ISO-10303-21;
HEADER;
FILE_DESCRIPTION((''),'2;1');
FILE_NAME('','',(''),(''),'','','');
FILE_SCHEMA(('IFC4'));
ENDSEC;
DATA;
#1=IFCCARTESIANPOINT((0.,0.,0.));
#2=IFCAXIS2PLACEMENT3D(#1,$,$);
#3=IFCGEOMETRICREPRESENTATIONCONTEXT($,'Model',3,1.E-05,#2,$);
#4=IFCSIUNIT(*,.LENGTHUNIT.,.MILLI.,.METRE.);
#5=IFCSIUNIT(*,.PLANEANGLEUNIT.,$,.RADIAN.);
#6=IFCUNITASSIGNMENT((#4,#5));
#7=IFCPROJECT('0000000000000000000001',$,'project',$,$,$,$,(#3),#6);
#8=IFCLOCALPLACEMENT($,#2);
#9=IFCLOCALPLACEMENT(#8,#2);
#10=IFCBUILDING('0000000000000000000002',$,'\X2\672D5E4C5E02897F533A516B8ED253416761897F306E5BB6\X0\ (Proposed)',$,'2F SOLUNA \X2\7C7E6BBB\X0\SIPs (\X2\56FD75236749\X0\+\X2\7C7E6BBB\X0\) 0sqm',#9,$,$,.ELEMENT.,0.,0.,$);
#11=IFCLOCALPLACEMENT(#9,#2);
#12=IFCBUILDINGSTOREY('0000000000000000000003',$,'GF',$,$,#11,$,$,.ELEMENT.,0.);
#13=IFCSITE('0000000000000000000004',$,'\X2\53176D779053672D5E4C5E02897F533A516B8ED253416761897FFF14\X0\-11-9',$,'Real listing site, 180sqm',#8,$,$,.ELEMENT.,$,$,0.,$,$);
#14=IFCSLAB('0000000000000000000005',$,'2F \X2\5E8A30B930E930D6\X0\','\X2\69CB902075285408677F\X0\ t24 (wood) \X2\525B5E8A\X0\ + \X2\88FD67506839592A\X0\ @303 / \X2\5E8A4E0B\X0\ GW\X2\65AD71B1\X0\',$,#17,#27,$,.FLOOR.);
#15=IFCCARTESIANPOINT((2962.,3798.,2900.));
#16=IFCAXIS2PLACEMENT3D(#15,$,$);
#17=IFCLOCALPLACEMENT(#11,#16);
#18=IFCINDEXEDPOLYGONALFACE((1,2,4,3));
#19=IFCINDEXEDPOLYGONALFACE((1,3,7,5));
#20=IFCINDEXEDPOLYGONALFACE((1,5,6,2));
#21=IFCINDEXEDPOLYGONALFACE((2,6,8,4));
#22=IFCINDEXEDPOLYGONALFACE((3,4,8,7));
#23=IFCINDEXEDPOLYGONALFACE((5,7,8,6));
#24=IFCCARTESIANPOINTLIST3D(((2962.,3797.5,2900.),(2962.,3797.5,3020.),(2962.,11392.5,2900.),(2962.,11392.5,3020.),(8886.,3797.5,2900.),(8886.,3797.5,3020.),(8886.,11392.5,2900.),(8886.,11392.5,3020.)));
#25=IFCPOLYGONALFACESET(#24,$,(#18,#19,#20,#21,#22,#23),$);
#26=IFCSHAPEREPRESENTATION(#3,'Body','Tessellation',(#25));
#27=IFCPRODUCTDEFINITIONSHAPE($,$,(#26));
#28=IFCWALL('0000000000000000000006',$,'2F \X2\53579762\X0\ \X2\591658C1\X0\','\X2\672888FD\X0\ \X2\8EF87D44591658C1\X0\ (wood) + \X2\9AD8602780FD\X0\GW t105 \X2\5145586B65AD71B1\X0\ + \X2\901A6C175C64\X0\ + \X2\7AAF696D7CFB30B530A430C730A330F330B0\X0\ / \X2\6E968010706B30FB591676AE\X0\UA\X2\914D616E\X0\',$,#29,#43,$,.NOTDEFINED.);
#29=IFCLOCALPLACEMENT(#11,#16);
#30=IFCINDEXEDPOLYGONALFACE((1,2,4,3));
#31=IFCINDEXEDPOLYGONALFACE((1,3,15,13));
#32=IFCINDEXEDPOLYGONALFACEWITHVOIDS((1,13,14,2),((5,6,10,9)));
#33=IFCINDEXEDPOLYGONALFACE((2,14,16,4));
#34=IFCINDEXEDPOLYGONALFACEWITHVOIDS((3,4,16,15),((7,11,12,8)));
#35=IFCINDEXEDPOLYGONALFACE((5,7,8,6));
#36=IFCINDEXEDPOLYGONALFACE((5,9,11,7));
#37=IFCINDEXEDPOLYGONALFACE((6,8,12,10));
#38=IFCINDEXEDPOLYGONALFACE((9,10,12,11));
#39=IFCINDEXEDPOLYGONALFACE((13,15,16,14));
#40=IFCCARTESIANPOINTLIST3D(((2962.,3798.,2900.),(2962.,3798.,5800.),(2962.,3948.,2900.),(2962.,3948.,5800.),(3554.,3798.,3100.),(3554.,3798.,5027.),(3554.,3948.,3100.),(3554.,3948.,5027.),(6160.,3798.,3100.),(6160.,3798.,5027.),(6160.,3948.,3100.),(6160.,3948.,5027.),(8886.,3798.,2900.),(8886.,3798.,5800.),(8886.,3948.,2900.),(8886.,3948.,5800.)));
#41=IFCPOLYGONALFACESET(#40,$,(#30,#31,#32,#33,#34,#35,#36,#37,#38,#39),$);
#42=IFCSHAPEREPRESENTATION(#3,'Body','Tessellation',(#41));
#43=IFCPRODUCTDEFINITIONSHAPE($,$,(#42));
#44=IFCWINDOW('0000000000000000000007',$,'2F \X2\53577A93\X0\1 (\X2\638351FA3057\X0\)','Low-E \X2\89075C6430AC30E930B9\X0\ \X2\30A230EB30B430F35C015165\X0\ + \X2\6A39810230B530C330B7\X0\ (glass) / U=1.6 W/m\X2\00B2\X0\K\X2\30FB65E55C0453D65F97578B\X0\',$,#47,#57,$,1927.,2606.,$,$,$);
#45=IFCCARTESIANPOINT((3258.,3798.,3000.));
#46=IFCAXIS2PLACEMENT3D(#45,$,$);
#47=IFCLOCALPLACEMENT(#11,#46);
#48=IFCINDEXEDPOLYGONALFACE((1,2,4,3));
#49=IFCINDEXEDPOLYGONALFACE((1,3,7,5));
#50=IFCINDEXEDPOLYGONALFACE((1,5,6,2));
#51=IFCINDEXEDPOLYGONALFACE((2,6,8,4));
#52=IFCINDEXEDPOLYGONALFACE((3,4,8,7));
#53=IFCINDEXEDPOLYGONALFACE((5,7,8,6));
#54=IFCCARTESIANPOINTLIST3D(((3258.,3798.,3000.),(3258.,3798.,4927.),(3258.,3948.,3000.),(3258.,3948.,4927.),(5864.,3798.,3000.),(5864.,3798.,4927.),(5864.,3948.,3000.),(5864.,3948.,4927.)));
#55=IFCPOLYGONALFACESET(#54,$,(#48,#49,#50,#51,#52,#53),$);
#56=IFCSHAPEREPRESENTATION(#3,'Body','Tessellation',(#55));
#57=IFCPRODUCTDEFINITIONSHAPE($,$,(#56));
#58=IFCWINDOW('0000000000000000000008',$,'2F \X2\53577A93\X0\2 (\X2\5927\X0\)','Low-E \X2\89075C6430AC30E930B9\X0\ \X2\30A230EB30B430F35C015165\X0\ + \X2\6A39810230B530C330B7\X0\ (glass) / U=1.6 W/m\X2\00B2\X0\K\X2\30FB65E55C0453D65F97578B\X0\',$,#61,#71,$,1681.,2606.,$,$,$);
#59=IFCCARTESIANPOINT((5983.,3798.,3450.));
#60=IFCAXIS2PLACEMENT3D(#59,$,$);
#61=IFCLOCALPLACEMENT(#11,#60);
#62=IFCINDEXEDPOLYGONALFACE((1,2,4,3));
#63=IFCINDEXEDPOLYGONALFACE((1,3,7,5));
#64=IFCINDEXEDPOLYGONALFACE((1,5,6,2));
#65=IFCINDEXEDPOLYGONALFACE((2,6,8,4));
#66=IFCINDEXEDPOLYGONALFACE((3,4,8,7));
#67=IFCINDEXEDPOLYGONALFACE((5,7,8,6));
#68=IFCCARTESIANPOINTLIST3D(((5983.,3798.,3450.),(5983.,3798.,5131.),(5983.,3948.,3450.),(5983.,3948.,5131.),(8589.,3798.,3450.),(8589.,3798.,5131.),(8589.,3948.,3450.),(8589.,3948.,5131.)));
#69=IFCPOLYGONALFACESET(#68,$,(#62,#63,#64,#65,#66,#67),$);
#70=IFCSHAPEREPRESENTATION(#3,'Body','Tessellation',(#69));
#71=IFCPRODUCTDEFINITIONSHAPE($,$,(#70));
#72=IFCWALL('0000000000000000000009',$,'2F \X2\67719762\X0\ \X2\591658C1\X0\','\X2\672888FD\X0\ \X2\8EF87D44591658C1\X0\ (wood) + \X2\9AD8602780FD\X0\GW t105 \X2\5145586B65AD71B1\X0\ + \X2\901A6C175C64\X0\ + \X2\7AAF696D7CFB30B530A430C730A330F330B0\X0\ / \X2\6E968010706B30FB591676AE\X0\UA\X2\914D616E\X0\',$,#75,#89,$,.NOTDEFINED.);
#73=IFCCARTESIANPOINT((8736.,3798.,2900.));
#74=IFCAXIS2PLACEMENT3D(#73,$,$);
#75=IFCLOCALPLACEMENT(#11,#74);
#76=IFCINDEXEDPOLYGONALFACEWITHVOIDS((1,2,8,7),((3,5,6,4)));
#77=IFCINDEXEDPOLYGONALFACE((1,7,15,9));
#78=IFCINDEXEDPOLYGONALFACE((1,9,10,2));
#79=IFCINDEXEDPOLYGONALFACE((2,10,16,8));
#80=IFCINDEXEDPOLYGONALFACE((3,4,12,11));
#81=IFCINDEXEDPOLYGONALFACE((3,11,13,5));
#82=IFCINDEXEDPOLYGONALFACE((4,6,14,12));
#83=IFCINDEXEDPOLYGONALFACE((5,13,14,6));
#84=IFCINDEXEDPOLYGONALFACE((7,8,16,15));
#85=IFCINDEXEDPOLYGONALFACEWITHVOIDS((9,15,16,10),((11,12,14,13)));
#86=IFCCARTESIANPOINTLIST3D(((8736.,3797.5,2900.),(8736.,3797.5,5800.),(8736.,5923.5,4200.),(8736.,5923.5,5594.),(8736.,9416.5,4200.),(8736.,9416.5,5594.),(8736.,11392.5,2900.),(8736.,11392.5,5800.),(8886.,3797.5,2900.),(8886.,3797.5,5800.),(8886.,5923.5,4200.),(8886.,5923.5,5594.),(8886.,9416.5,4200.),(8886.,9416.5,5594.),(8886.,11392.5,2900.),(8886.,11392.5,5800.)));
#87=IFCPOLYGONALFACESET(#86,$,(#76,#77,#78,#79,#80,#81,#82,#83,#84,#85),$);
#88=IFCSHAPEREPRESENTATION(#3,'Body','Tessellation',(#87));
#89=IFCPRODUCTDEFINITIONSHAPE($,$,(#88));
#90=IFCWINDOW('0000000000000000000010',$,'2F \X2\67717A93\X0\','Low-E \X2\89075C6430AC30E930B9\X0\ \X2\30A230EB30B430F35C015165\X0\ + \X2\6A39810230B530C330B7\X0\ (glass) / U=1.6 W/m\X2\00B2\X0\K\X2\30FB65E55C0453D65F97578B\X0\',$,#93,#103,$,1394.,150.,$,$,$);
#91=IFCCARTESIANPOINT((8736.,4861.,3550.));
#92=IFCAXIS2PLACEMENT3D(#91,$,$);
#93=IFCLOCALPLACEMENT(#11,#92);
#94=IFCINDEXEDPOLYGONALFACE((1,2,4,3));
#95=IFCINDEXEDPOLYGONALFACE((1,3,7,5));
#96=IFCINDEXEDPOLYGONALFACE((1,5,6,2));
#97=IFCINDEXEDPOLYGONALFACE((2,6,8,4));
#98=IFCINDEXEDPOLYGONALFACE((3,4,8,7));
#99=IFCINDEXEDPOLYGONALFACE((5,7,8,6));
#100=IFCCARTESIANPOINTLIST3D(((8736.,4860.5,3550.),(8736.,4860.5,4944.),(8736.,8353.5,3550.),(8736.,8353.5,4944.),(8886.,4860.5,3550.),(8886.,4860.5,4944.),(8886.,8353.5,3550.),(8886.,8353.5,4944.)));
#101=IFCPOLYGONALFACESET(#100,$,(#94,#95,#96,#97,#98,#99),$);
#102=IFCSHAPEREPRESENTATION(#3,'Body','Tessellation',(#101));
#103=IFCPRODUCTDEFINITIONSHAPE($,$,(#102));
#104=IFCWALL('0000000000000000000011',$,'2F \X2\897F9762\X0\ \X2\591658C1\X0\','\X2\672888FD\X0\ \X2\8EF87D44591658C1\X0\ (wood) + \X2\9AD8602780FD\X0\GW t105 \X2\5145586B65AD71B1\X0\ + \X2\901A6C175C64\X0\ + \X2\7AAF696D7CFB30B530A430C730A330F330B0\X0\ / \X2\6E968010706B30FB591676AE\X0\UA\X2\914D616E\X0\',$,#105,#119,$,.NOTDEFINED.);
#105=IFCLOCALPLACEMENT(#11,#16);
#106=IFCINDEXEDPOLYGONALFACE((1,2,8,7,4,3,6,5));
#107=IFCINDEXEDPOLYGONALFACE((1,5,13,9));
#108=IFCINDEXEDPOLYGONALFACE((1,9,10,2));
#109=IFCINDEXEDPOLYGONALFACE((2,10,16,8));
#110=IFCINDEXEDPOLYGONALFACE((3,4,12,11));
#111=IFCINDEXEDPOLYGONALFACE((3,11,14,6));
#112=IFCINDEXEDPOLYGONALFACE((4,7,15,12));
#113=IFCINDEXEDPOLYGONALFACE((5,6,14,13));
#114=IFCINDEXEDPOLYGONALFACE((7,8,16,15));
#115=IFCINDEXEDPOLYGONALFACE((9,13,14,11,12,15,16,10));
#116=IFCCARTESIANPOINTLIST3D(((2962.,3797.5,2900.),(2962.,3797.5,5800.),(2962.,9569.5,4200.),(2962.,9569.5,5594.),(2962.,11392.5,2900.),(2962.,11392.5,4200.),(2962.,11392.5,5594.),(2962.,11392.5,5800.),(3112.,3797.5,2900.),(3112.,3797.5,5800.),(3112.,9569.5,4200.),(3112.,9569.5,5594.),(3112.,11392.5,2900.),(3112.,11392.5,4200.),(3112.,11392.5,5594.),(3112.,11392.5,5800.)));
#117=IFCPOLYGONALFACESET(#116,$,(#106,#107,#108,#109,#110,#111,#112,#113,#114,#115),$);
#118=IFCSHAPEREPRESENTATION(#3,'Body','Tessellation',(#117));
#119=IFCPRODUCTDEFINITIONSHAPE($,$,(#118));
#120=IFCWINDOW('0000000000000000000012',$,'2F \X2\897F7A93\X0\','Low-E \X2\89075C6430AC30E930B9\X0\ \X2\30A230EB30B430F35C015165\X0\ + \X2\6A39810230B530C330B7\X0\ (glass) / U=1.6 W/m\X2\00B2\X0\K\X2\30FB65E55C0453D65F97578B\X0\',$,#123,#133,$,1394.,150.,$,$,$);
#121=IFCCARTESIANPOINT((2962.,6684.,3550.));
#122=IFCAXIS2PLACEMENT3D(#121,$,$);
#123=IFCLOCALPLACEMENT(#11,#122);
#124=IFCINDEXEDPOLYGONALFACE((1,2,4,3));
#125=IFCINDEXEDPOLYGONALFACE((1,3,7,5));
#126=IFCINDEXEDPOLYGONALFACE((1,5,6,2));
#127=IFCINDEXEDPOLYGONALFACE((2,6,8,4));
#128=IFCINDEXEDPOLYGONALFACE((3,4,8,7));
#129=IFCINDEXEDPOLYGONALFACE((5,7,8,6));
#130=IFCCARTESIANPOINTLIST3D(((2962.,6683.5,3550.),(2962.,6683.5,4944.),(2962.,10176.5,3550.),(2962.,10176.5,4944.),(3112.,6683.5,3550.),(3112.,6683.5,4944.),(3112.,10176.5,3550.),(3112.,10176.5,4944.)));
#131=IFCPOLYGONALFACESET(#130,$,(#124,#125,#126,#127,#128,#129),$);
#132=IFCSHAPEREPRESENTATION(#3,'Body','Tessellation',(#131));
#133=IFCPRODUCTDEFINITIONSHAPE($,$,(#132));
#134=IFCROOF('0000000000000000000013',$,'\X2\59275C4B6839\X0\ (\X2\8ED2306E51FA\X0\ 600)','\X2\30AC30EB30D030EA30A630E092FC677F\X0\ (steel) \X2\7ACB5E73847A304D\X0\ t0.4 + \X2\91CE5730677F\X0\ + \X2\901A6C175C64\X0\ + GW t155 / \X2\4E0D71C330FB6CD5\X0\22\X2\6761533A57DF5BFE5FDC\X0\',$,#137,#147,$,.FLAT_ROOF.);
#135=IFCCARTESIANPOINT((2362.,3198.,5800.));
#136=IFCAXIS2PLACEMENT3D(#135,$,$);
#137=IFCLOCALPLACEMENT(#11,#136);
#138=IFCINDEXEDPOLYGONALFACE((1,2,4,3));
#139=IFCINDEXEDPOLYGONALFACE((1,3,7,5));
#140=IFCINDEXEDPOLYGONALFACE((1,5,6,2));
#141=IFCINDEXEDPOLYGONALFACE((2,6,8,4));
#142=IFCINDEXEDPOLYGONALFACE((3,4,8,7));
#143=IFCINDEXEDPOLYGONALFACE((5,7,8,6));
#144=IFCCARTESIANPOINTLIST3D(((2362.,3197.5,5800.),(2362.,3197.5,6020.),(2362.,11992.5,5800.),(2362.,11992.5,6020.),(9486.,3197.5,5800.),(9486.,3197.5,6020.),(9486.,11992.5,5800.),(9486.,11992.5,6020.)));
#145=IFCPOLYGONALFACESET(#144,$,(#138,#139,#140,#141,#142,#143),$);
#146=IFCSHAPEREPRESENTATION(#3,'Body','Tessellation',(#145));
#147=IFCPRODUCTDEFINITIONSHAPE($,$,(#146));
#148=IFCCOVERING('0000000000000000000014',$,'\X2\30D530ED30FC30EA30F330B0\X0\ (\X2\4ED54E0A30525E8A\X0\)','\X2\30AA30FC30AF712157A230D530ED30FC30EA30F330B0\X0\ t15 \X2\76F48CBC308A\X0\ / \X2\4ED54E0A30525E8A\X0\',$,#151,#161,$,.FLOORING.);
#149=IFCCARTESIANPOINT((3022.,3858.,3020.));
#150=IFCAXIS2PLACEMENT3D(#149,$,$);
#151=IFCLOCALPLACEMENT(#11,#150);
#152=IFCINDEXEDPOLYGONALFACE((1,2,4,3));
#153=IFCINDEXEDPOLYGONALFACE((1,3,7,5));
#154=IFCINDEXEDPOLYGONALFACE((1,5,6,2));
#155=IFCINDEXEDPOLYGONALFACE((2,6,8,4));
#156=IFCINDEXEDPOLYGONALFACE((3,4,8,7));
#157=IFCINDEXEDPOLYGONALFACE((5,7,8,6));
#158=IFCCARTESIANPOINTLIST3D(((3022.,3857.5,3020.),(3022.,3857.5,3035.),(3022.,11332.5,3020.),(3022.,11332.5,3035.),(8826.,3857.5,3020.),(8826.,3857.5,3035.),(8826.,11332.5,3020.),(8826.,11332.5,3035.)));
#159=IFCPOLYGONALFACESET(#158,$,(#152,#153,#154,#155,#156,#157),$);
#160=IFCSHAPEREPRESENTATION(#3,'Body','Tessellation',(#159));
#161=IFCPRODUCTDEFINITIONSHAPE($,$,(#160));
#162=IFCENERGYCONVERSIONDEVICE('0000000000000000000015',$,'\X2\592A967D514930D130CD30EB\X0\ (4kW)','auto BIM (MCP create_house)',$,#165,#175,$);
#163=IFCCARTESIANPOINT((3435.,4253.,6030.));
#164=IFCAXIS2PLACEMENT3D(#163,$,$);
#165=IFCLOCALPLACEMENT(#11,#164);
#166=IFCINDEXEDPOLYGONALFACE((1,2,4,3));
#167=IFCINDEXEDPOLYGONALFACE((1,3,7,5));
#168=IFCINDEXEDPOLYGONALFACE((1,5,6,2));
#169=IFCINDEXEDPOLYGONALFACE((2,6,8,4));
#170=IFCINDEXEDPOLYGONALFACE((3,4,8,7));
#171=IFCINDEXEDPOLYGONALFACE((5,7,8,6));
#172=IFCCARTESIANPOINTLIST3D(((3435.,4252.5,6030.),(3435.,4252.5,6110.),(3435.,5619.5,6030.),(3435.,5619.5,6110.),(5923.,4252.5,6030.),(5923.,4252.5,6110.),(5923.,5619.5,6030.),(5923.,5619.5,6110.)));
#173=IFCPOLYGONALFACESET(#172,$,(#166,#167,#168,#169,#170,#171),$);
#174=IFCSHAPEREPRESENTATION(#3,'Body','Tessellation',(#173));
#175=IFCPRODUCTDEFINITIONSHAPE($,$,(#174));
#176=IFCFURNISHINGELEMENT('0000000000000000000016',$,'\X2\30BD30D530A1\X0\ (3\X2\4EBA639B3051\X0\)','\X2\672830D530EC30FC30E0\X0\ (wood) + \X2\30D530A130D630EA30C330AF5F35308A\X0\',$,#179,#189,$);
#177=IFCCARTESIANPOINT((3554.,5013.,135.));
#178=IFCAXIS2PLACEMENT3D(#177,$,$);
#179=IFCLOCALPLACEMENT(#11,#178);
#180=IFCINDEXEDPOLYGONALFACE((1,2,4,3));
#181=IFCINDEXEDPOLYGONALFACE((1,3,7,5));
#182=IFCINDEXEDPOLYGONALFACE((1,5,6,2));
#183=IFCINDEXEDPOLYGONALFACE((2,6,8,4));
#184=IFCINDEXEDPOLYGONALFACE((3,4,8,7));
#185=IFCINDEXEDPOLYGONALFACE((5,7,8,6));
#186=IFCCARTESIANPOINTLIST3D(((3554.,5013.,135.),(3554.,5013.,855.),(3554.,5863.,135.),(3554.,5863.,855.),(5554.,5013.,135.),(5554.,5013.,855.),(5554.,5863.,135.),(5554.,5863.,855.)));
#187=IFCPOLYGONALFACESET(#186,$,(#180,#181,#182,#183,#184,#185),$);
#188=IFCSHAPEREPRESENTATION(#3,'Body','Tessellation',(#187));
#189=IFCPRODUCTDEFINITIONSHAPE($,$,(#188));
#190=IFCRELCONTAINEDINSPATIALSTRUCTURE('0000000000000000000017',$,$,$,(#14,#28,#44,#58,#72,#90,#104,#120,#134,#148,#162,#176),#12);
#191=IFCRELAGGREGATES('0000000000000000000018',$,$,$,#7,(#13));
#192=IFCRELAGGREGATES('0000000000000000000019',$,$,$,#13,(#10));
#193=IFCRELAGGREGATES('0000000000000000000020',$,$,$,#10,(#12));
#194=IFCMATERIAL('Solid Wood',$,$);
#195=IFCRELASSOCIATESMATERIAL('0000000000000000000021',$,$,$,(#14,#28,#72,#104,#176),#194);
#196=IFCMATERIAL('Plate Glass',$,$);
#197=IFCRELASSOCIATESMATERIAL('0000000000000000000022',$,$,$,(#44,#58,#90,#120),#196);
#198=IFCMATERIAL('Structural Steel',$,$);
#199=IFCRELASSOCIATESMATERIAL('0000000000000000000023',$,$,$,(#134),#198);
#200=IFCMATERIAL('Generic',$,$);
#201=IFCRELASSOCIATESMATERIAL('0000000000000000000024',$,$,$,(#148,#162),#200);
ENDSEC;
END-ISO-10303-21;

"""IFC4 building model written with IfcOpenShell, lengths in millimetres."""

from ifc_helpers import new_model, si_unit, frame, frame_2d, origin, place, context, project, spatial, rectangle, extrude, material, element, fill, save


model = new_model("IFC4")

# Units and contexts
model_context = context("Model", 3, precision=1e-05, world=origin())
ifc_project = project(units=[si_unit("LENGTHUNIT", "METRE", prefix="MILLI"), si_unit("PLANEANGLEUNIT", "RADIAN")], contexts=[model_context])

# Site, building, storey
site_placement = place(None, origin())
site = spatial("IfcSite", under=ifc_project, at=site_placement, Name="北海道札幌市西区八軒十条西４-11-9", ObjectType="Real listing site, 180sqm", CompositionType="ELEMENT", RefElevation=0.0)
building_placement = place(site_placement, origin())
building = spatial("IfcBuilding", under=site, at=building_placement, Name="札幌市西区八軒十条西の家 (Proposed)", ObjectType="2F SOLUNA 籾殻SIPs (国産杉+籾殻) 0sqm", CompositionType="ELEMENT", ElevationOfRefHeight=0.0, ElevationOfTerrain=0.0)
storey_placement = place(building_placement, origin())
storey = spatial("IfcBuildingStorey", under=building, at=storey_placement, Name="GF", CompositionType="ELEMENT", Elevation=0.0)

# Slab
ifc_material_1 = material(Name="Solid Wood")
slab_placement = place(storey_placement, frame((2962.0, 3798.0, 2900.0)))
element("IfcSlab", 1, at=slab_placement, inside=storey, material=ifc_material_1, Name="2F 床スラブ", Description="構造用合板 t24 (wood) 剛床 + 製材根太 @303 / 床下 GW断熱", PredefinedType="FLOOR", context=model_context, shape_type="SweptSolid", body=[
    extrude(rectangle(XDim=5924.0, YDim=7595.0, at=frame_2d((2962.0, 3797.0))), frame((2962.0, 3798.0, 2900.0)), (0.0, 0.0, 1.0), 120.0),
])

# Wall, openings, windows
wall_1_placement = place(storey_placement, frame((2962.0, 3798.0, 2900.0)))
wall_1 = element("IfcWall", 2, at=wall_1_placement, inside=storey, material=ifc_material_1, Name="2F 南面 外壁", Description="木製 軸組外壁 (wood) + 高性能GW t105 充填断熱 + 通気層 + 窯業系サイディング / 準耐火・外皮UA配慮", PredefinedType="NOTDEFINED", context=model_context, shape_type="SweptSolid", body=[
    extrude(rectangle(XDim=5924.0, YDim=150.0, at=frame_2d((2962.0, 75.0))), frame((2962.0, 3798.0, 2900.0)), (0.0, 0.0, 1.0), 2900.0),
])
opening_1_placement = place(storey_placement, frame((3258.0, 3798.0, 3000.0)))
opening_1 = element("IfcOpeningElement", 3, at=opening_1_placement, cuts=wall_1, PredefinedType="NOTDEFINED", context=model_context, shape_type="SweptSolid", body=[
    extrude(rectangle(XDim=2606.0, YDim=150.0, at=frame_2d((1303.0, 75.0))), frame((3258.0, 3798.0, 3000.0)), (0.0, 0.0, 1.0), 1927.0),
])
opening_2_placement = place(storey_placement, frame((5983.0, 3798.0, 3450.0)))
opening_2 = element("IfcOpeningElement", 4, at=opening_2_placement, cuts=wall_1, PredefinedType="NOTDEFINED", context=model_context, shape_type="SweptSolid", body=[
    extrude(rectangle(XDim=2606.0, YDim=150.0, at=frame_2d((1303.0, 75.0))), frame((5983.0, 3798.0, 3450.0)), (0.0, 0.0, 1.0), 1681.0),
])
ifc_material_2 = material(Name="Plate Glass")
window_1_placement = place(storey_placement, frame((3258.0, 3798.0, 3000.0)))
window_1 = element("IfcWindow", 5, at=window_1_placement, inside=storey, material=ifc_material_2, Name="2F 南窓1 (掃出し)", Description="Low-E 複層ガラス アルゴン封入 + 樹脂サッシ (glass) / U=1.6 W/m²K・日射取得型", OverallHeight=1927.0, OverallWidth=2606.0, context=model_context, shape_type="SweptSolid", body=[
    extrude(rectangle(XDim=2606.0, YDim=150.0, at=frame_2d((1303.0, 75.0))), frame((3258.0, 3798.0, 3000.0)), (0.0, 0.0, 1.0), 1927.0),
])
fill(opening_1, window_1)
window_2_placement = place(storey_placement, frame((5983.0, 3798.0, 3450.0)))
window_2 = element("IfcWindow", 6, at=window_2_placement, inside=storey, material=ifc_material_2, Name="2F 南窓2 (大)", Description="Low-E 複層ガラス アルゴン封入 + 樹脂サッシ (glass) / U=1.6 W/m²K・日射取得型", OverallHeight=1681.0, OverallWidth=2606.0, context=model_context, shape_type="SweptSolid", body=[
    extrude(rectangle(XDim=2606.0, YDim=150.0, at=frame_2d((1303.0, 75.0))), frame((5983.0, 3798.0, 3450.0)), (0.0, 0.0, 1.0), 1681.0),
])
fill(opening_2, window_2)

# Walls, openings, windows
wall_2_placement = place(storey_placement, frame((8736.0, 3798.0, 2900.0)))
wall_2 = element("IfcWall", 7, at=wall_2_placement, inside=storey, material=ifc_material_1, Name="2F 東面 外壁", Description="木製 軸組外壁 (wood) + 高性能GW t105 充填断熱 + 通気層 + 窯業系サイディング / 準耐火・外皮UA配慮", PredefinedType="NOTDEFINED", context=model_context, shape_type="SweptSolid", body=[
    extrude(rectangle(XDim=150.0, YDim=7595.0, at=frame_2d((75.0, 3797.0))), frame((8736.0, 3798.0, 2900.0)), (0.0, 0.0, 1.0), 2900.0),
])
opening_3_placement = place(storey_placement, frame((8736.0, 4861.0, 3550.0)))
opening_3 = element("IfcOpeningElement", 8, at=opening_3_placement, cuts=wall_2, PredefinedType="NOTDEFINED", context=model_context, shape_type="SweptSolid", body=[
    extrude(rectangle(XDim=150.0, YDim=3493.0, at=frame_2d((75.0, 1746.0))), frame((8736.0, 4861.0, 3550.0)), (0.0, 0.0, 1.0), 1394.0),
])
window_3_placement = place(storey_placement, frame((8736.0, 4861.0, 3550.0)))
window_3 = element("IfcWindow", 9, at=window_3_placement, inside=storey, material=ifc_material_2, Name="2F 東窓", Description="Low-E 複層ガラス アルゴン封入 + 樹脂サッシ (glass) / U=1.6 W/m²K・日射取得型", OverallHeight=1394.0, OverallWidth=150.0, context=model_context, shape_type="SweptSolid", body=[
    extrude(rectangle(XDim=150.0, YDim=3493.0, at=frame_2d((75.0, 1746.0))), frame((8736.0, 4861.0, 3550.0)), (0.0, 0.0, 1.0), 1394.0),
])
fill(opening_3, window_3)
wall_3_placement = place(storey_placement, frame((2962.0, 3798.0, 2900.0)))
wall_3 = element("IfcWall", 10, at=wall_3_placement, inside=storey, material=ifc_material_1, Name="2F 西面 外壁", Description="木製 軸組外壁 (wood) + 高性能GW t105 充填断熱 + 通気層 + 窯業系サイディング / 準耐火・外皮UA配慮", PredefinedType="NOTDEFINED", context=model_context, shape_type="SweptSolid", body=[
    extrude(rectangle(XDim=150.0, YDim=7595.0, at=frame_2d((75.0, 3797.0))), frame((2962.0, 3798.0, 2900.0)), (0.0, 0.0, 1.0), 2900.0),
])
opening_4_placement = place(storey_placement, frame((2962.0, 6684.0, 3550.0)))
opening_4 = element("IfcOpeningElement", 11, at=opening_4_placement, cuts=wall_3, PredefinedType="NOTDEFINED", context=model_context, shape_type="SweptSolid", body=[
    extrude(rectangle(XDim=150.0, YDim=3493.0, at=frame_2d((75.0, 1746.0))), frame((2962.0, 6684.0, 3550.0)), (0.0, 0.0, 1.0), 1394.0),
])
window_4_placement = place(storey_placement, frame((2962.0, 6684.0, 3550.0)))
window_4 = element("IfcWindow", 12, at=window_4_placement, inside=storey, material=ifc_material_2, Name="2F 西窓", Description="Low-E 複層ガラス アルゴン封入 + 樹脂サッシ (glass) / U=1.6 W/m²K・日射取得型", OverallHeight=1394.0, OverallWidth=150.0, context=model_context, shape_type="SweptSolid", body=[
    extrude(rectangle(XDim=150.0, YDim=3493.0, at=frame_2d((75.0, 1746.0))), frame((2962.0, 6684.0, 3550.0)), (0.0, 0.0, 1.0), 1394.0),
])
fill(opening_4, window_4)

# Roof
ifc_material_3 = material(Name="Structural Steel")
roof_placement = place(storey_placement, frame((2362.0, 3198.0, 5800.0)))
element("IfcRoof", 13, at=roof_placement, inside=storey, material=ifc_material_3, Name="大屋根 (軒の出 600)", Description="ガルバリウム鋼板 (steel) 立平葺き t0.4 + 野地板 + 通気層 + GW t155 / 不燃・法22条区域対応", PredefinedType="FLAT_ROOF", context=model_context, shape_type="SweptSolid", body=[
    extrude(rectangle(XDim=7124.0, YDim=8795.0, at=frame_2d((3562.0, 4397.0))), frame((2362.0, 3198.0, 5800.0)), (0.0, 0.0, 1.0), 220.0),
])

# Covering
ifc_material_4 = material(Name="Generic")
covering_placement = place(storey_placement, frame((3022.0, 3858.0, 3020.0)))
element("IfcCovering", 14, at=covering_placement, inside=storey, material=ifc_material_4, Name="フローリング (仕上げ床)", Description="オーク無垢フローリング t15 直貼り / 仕上げ床", PredefinedType="FLOORING", context=model_context, shape_type="SweptSolid", body=[
    extrude(rectangle(XDim=5804.0, YDim=7475.0, at=frame_2d((2902.0, 3737.0))), frame((3022.0, 3858.0, 3020.0)), (0.0, 0.0, 1.0), 15.0),
])

# Energy conversion device
energy_conversion_device_placement = place(storey_placement, frame((3435.0, 4253.0, 6030.0)))
element("IfcEnergyConversionDevice", 15, at=energy_conversion_device_placement, inside=storey, material=ifc_material_4, Name="太陽光パネル (4kW)", Description="auto BIM (MCP create_house)", context=model_context, shape_type="SweptSolid", body=[
    extrude(rectangle(XDim=2488.0, YDim=1367.0, at=frame_2d((1244.0, 683.0))), frame((3435.0, 4253.0, 6030.0)), (0.0, 0.0, 1.0), 80.0),
])

# Furnishing element
furnishing_1_placement = place(storey_placement, frame((3554.0, 5013.0, 135.0)))
element("IfcFurnishingElement", 16, at=furnishing_1_placement, inside=storey, material=ifc_material_1, Name="ソファ (3人掛け)", Description="木フレーム (wood) + ファブリック張り", context=model_context, shape_type="SweptSolid", body=[
    extrude(rectangle(XDim=2000.0, YDim=850.0, at=frame_2d((1000.0, 425.0))), frame((3554.0, 5013.0, 135.0)), (0.0, 0.0, 1.0), 720.0),
])

save(model, "model.ifc")
